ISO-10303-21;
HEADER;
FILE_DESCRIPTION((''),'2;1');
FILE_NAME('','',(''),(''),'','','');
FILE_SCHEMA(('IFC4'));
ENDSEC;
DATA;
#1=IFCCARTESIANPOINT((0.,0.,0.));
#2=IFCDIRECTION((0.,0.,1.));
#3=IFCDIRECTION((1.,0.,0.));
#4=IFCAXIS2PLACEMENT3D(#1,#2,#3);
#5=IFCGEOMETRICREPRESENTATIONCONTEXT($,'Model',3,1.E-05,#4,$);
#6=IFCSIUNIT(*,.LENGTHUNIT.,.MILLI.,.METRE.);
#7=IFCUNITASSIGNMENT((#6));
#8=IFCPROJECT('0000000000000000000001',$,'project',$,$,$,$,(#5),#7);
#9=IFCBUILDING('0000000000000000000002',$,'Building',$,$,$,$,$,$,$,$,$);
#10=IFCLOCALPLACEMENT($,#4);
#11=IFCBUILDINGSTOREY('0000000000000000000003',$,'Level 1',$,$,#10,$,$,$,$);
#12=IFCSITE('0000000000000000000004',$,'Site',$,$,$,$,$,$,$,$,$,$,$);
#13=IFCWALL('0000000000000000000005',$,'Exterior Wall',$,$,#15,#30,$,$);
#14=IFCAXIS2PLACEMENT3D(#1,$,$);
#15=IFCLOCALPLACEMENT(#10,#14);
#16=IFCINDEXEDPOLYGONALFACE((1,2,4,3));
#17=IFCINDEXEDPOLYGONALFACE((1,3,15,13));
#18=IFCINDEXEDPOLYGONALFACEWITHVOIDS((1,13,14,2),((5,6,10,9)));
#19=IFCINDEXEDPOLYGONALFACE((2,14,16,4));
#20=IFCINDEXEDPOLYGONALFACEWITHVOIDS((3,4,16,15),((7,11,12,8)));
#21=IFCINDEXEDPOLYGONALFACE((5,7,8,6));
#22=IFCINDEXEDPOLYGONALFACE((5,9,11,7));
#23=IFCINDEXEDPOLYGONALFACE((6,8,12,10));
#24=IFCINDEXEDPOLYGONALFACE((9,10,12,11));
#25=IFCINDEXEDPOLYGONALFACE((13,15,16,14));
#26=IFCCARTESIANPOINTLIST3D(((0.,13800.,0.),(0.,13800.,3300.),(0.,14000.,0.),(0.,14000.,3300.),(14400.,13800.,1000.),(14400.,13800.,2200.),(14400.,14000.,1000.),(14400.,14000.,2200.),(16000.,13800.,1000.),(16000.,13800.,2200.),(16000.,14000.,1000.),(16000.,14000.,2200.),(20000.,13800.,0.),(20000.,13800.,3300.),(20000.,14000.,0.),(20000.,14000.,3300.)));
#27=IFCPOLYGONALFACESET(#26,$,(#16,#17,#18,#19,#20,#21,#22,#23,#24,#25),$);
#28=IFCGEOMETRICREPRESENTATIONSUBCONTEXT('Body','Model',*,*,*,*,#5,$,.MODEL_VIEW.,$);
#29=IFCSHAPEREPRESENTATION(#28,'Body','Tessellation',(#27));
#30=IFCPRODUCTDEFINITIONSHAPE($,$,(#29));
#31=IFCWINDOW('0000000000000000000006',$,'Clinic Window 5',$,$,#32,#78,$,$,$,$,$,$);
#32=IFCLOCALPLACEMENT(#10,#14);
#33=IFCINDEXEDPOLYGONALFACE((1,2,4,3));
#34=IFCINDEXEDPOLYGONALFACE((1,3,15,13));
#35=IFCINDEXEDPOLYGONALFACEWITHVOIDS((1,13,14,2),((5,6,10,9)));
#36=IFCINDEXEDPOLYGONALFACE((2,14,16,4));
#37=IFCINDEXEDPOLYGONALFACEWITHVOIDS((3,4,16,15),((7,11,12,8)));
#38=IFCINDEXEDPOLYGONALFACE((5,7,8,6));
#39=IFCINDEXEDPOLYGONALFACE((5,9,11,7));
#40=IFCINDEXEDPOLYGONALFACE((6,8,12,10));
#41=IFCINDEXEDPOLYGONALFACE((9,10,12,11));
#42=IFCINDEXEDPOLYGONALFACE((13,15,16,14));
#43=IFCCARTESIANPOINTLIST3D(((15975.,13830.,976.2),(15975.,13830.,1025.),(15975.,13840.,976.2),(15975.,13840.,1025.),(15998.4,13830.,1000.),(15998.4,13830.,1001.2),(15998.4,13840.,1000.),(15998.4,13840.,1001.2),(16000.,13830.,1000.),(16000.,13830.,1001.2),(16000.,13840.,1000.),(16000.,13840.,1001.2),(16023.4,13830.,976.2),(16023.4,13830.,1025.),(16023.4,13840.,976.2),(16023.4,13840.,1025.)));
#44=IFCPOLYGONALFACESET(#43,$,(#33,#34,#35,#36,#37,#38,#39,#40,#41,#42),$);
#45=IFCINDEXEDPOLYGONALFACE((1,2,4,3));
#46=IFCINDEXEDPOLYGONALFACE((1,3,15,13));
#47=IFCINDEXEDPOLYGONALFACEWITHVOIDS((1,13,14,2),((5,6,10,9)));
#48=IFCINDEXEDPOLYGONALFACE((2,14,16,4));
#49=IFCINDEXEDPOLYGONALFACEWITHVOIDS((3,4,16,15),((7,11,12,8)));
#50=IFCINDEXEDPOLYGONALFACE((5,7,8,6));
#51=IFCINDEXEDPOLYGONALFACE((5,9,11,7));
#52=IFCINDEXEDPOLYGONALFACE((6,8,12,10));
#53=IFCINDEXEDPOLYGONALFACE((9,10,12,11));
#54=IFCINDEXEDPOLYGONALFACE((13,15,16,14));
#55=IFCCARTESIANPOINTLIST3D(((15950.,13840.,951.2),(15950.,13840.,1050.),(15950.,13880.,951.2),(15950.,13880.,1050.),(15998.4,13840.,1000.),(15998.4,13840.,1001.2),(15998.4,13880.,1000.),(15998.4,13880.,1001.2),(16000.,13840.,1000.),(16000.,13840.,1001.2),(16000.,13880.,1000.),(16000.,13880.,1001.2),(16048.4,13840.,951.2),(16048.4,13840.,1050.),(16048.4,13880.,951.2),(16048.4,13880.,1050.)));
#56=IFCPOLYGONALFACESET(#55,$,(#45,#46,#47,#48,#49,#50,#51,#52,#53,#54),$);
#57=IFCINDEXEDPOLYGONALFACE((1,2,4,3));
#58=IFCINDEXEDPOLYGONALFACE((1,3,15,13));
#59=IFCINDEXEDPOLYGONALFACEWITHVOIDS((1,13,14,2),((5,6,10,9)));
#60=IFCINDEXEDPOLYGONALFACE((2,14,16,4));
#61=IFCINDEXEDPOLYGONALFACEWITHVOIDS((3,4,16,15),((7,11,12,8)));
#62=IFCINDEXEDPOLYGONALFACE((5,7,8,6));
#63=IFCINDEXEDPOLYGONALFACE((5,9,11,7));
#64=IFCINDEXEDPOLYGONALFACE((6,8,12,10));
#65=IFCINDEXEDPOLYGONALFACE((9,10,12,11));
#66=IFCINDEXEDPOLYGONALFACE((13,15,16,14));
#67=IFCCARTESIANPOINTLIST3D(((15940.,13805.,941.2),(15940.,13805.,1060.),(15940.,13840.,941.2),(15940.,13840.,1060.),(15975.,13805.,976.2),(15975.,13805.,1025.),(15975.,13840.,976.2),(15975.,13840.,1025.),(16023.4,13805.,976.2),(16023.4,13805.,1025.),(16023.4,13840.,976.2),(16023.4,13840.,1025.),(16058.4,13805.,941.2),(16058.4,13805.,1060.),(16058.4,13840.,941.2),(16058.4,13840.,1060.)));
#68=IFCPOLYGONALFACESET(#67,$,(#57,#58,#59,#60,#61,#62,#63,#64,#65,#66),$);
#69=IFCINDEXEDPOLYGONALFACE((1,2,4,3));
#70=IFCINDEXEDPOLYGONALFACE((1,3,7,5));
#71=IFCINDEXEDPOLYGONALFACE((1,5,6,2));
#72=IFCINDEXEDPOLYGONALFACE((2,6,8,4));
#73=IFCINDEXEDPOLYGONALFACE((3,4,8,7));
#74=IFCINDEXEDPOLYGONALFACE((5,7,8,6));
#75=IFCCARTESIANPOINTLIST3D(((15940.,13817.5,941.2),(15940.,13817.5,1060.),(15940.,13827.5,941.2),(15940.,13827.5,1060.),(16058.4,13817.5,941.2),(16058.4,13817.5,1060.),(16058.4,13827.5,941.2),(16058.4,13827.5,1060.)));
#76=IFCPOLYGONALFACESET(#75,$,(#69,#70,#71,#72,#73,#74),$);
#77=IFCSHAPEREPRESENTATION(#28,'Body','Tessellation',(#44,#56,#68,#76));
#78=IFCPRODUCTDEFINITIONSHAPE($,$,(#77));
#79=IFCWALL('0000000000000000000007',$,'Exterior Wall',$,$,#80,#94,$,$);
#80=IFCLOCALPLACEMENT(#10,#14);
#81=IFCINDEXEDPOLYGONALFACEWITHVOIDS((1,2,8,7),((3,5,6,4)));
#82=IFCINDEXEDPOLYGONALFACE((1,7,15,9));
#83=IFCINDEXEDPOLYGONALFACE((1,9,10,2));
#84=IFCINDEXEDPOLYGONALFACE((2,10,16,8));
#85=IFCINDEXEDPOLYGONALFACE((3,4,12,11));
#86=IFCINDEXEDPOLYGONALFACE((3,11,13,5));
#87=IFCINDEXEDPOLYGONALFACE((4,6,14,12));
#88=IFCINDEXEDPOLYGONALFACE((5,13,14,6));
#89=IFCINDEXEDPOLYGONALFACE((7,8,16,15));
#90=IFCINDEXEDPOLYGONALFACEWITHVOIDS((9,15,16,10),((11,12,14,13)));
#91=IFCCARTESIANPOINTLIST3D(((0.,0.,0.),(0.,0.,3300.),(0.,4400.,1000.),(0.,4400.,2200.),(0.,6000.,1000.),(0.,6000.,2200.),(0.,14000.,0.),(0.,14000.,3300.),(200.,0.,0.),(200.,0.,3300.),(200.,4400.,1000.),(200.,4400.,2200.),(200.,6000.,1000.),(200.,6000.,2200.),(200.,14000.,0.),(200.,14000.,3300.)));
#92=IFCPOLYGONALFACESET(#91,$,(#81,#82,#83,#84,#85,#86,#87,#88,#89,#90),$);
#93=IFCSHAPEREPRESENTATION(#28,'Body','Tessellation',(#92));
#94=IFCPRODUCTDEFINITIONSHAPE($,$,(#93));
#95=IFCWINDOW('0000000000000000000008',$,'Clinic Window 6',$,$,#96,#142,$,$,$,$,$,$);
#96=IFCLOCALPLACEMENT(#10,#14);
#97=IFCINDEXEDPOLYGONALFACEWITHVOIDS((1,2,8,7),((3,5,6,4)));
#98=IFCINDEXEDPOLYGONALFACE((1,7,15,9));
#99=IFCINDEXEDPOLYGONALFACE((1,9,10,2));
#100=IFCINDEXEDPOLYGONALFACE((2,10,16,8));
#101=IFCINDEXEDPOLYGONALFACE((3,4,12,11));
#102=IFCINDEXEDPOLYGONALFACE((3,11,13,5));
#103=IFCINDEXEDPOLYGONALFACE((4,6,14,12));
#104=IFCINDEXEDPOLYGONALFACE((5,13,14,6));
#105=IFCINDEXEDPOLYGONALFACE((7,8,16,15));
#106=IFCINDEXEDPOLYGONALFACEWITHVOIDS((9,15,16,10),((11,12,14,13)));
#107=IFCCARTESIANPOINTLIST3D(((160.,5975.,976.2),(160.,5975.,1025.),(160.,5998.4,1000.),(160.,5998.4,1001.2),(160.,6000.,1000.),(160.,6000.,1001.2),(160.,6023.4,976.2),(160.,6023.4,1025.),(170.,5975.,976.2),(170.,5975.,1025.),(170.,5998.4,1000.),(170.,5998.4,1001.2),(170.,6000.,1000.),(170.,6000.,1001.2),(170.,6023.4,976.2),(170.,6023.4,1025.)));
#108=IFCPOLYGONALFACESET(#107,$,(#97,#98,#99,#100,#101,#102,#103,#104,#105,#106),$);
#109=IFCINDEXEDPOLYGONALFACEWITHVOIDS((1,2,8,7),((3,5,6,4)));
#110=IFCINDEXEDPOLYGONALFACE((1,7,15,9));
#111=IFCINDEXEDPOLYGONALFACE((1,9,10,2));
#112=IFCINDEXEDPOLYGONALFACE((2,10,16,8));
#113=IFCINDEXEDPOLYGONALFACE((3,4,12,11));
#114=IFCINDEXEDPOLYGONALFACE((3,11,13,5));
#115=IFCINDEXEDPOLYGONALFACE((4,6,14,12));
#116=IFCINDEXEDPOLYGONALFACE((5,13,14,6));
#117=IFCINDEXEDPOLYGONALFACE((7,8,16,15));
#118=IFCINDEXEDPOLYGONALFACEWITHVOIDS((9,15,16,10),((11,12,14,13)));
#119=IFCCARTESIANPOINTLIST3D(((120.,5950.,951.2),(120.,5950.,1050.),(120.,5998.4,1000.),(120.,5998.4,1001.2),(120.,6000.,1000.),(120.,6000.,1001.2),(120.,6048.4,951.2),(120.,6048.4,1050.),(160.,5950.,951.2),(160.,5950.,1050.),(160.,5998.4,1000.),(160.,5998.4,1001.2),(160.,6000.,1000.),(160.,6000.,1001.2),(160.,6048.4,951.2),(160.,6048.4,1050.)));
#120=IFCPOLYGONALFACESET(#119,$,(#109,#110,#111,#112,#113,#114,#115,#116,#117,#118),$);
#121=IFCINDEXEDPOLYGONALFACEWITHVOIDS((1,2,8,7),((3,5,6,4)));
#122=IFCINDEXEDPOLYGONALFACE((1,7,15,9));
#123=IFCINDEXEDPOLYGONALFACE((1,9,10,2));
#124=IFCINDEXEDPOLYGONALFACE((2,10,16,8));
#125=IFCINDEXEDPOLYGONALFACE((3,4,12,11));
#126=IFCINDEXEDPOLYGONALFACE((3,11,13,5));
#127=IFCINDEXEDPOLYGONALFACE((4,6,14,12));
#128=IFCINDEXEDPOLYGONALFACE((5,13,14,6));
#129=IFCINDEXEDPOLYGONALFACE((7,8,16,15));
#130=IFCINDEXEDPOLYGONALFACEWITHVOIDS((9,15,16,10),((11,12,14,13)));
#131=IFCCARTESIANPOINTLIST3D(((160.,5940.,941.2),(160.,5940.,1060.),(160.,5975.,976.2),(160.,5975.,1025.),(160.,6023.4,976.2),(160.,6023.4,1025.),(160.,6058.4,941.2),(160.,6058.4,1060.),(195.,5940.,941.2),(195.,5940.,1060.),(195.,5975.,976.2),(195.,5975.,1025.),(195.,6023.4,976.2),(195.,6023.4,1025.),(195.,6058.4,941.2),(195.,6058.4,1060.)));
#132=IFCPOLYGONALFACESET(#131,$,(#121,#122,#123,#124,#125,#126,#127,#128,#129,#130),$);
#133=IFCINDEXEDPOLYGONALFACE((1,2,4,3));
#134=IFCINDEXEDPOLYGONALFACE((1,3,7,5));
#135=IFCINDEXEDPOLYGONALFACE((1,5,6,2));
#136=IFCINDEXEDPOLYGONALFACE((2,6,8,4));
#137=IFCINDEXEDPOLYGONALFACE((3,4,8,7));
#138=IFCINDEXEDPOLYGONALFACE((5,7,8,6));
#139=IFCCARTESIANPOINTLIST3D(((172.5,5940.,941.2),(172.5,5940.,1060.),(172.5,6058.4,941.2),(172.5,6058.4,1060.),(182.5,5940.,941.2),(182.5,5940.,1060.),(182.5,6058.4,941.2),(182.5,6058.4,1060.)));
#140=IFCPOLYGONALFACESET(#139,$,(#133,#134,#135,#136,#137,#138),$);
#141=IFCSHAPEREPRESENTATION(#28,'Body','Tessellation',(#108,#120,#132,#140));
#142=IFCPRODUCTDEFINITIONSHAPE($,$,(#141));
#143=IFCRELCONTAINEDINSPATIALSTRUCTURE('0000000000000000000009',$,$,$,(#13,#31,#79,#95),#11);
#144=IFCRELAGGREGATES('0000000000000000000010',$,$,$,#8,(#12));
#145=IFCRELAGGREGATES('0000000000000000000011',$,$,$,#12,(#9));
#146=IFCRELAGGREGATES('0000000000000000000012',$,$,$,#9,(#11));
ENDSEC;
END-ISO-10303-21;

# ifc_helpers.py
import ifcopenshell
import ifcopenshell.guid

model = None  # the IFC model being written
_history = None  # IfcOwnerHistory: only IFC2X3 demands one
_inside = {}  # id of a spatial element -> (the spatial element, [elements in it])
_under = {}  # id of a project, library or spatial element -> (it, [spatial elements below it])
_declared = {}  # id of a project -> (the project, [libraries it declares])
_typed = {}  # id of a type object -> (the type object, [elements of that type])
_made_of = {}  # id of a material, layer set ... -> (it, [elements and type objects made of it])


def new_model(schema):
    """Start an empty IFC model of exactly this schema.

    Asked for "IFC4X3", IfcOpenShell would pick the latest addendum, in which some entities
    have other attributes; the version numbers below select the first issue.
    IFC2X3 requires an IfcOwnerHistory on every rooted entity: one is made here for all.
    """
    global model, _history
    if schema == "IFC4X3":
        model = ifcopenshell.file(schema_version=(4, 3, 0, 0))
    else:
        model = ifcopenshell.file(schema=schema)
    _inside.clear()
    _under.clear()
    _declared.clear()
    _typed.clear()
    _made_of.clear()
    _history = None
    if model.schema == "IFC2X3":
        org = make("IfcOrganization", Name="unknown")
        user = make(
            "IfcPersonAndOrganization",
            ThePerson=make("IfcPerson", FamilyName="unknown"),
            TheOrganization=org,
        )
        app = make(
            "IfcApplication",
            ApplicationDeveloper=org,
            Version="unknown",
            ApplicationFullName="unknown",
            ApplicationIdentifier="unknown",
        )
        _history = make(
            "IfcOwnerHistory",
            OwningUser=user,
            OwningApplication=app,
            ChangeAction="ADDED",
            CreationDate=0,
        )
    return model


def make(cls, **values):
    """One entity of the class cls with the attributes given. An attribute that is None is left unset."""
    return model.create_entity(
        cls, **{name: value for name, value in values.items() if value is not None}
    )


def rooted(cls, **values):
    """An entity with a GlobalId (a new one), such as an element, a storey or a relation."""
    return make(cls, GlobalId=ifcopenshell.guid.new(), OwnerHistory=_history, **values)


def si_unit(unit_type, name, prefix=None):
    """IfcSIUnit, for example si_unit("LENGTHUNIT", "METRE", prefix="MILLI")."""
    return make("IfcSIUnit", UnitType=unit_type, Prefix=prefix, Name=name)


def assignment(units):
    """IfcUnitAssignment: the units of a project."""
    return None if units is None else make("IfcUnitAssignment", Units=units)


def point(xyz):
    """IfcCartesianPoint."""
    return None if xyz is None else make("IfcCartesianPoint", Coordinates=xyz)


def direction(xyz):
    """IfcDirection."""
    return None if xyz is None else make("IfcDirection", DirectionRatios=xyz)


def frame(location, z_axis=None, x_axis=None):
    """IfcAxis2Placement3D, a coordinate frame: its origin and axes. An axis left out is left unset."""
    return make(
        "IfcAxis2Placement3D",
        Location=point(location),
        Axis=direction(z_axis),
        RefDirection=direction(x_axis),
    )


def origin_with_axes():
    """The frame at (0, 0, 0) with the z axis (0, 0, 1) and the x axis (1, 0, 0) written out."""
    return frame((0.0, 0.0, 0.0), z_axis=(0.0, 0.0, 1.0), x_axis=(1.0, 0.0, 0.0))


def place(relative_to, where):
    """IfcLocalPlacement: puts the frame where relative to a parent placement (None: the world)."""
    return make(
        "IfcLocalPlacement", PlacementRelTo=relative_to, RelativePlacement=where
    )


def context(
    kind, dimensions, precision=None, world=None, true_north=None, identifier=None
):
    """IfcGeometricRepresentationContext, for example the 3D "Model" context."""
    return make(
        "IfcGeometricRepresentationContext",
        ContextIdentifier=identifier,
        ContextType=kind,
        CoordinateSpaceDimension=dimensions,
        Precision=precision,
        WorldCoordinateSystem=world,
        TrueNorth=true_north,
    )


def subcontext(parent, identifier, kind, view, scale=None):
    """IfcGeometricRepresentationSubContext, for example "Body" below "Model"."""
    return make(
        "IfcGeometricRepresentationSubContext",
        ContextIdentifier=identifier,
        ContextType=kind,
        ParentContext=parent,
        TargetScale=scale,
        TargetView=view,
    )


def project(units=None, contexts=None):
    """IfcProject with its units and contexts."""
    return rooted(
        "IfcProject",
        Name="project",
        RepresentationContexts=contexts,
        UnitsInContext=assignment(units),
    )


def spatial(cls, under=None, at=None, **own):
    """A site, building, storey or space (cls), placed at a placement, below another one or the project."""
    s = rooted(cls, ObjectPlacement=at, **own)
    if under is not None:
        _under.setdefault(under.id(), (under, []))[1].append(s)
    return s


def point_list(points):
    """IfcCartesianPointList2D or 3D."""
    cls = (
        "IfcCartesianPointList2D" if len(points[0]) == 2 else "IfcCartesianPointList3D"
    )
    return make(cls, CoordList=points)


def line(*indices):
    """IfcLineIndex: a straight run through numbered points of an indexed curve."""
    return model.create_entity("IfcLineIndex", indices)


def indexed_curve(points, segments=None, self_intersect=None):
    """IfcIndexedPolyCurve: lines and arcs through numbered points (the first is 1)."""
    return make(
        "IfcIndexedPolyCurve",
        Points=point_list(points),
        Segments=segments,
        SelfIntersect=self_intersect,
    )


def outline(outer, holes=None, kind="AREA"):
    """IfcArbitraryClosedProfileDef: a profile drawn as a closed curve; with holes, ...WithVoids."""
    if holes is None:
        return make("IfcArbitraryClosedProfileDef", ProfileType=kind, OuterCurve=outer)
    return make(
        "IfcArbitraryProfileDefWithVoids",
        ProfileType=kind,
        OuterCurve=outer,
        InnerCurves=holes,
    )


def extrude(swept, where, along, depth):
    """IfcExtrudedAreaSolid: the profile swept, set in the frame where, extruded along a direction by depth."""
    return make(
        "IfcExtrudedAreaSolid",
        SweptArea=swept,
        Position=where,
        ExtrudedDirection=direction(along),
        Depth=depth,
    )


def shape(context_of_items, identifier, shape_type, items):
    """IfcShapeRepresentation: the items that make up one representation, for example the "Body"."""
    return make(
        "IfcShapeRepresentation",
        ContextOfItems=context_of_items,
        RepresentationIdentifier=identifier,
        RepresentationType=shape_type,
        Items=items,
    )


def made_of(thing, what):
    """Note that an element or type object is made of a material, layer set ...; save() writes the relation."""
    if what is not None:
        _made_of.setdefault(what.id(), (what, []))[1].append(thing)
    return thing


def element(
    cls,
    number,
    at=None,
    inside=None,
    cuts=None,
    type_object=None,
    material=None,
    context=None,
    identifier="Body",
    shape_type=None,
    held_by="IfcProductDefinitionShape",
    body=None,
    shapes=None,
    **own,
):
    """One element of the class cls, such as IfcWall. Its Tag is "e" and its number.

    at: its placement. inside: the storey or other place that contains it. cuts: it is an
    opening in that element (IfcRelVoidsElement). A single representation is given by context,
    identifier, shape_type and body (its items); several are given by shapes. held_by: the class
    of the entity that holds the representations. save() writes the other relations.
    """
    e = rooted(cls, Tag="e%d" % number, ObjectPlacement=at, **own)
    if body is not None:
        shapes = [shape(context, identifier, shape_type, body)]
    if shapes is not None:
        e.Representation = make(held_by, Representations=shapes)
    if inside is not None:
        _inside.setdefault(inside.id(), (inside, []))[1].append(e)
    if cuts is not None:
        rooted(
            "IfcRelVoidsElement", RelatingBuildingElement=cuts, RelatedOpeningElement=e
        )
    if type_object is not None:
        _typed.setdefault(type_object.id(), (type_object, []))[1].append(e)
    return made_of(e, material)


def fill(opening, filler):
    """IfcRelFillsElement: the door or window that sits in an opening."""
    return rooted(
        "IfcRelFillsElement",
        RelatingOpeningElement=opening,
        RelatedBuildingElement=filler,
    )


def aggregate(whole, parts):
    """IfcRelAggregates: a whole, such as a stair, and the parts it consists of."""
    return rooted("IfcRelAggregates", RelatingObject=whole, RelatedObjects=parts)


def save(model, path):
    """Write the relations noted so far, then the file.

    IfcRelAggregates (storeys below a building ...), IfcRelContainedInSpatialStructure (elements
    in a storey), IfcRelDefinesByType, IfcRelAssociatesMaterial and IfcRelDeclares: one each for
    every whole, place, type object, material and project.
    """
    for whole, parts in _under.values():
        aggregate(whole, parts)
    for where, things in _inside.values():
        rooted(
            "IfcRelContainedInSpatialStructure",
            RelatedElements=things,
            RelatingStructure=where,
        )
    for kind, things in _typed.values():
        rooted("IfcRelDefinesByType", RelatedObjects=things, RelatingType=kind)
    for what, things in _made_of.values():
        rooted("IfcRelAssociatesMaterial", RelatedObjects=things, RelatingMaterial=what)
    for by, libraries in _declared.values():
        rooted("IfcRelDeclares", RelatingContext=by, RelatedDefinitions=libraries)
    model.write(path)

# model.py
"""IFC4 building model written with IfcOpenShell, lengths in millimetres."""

from ifc_helpers import new_model, si_unit, frame, origin_with_axes, place, context, subcontext, project, spatial, line, indexed_curve, outline, extrude, element, fill, save


model = new_model("IFC4")

# Units and contexts
model_context = context("Model", 3, precision=1e-05, world=origin_with_axes())
body_context = subcontext(model_context, "Body", "Model", "MODEL_VIEW")
ifc_project = project(units=[si_unit("LENGTHUNIT", "METRE", prefix="MILLI")], contexts=[model_context])

# Site, building, storey
site = spatial("IfcSite", under=ifc_project, Name="Site")
building = spatial("IfcBuilding", under=site, Name="Building")
storey_placement = place(None, origin_with_axes())
storey = spatial("IfcBuildingStorey", under=building, at=storey_placement, Name="Level 1")

# Walls, openings, windows
wall_1_placement = place(storey_placement, frame((20000.0, 14000.0, 0.0), z_axis=(0.0, 0.0, 1.0), x_axis=(-1.0, 0.0, 0.0)))
wall_1 = element("IfcWall", 1, at=wall_1_placement, inside=storey, Name="Exterior Wall", context=body_context, shape_type="SweptSolid", body=[
    extrude(outline(indexed_curve([(0.0, 0.0), (0.0, 200.0), (20000.0, 200.0), (20000.0, 0.0), (0.0, 0.0)], self_intersect=False)), origin_with_axes(), (0.0, 0.0, 1.0), 3300.0),
])
opening_1_placement = place(wall_1_placement, frame((4000.0, -100.0, 1000.0), z_axis=(0.0, 0.0, 1.0), x_axis=(1.0, 0.0, 0.0)))
opening_1 = element("IfcOpeningElement", 2, at=opening_1_placement, cuts=wall_1, context=body_context, shape_type="SweptSolid", body=[
    extrude(outline(indexed_curve([(0.0, 0.0), (0.0, 400.0), (1600.0, 400.0), (1600.0, 0.0), (0.0, 0.0)], self_intersect=False)), origin_with_axes(), (0.0, 0.0, 1.0), 1200.0),
])
window_1_placement = place(opening_1_placement, frame((0.0, 170.0, 0.0), z_axis=(0.0, 0.0, 1.0), x_axis=(1.0, 0.0, 0.0)))
window_1 = element("IfcWindow", 3, at=window_1_placement, inside=storey, Name="Clinic Window 5", context=body_context, shape_type="SweptSolid", body=[
    extrude(outline(indexed_curve([(0.0, 0.0), (1.6, 0.0), (1.6, 1.2), (0.0, 1.2)], segments=[line(1, 2, 3, 4, 1)]), holes=[indexed_curve([(25.0, 25.0), (-23.4, 25.0), (-23.4, -23.8), (25.0, -23.8)], segments=[line(1, 2, 3, 4, 1)])]), frame((0.0, 90.0, 0.0), z_axis=(0.0, -1.0, 0.0), x_axis=(1.0, 0.0, 0.0)), (0.0, 0.0, -1.0), 10.0),
    extrude(outline(indexed_curve([(0.0, 0.0), (1.6, 0.0), (1.6, 1.2), (0.0, 1.2)], segments=[line(1, 2, 3, 4, 1)]), holes=[indexed_curve([(50.0, 50.0), (-48.4, 50.0), (-48.4, -48.8), (50.0, -48.8)], segments=[line(1, 2, 3, 4, 1)])]), frame((0.0, 50.0, 0.0), z_axis=(0.0, -1.0, 0.0), x_axis=(1.0, 0.0, 0.0)), (0.0, 0.0, -1.0), 40.0),
    extrude(outline(indexed_curve([(0.0, 0.0), (-48.4, 0.0), (-48.4, -48.8), (0.0, -48.8)], segments=[line(1, 2, 3, 4, 1)]), holes=[indexed_curve([(35.0, 35.0), (-83.4, 35.0), (-83.4, -83.8), (35.0, -83.8)], segments=[line(1, 2, 3, 4, 1)])]), frame((25.0, 90.0, 25.0), z_axis=(0.0, -1.0, 0.0), x_axis=(1.0, 0.0, 0.0)), (0.0, 0.0, -1.0), 35.0),
    extrude(outline(indexed_curve([(35.0, 35.0), (-83.4, 35.0), (-83.4, -83.8), (35.0, -83.8)], segments=[line(1, 2, 3, 4, 1)])), frame((25.0, 102.5, 25.0), z_axis=(0.0, -1.0, 0.0), x_axis=(1.0, 0.0, 0.0)), (0.0, 0.0, -1.0), 10.0),
])
fill(opening_1, window_1)
wall_2_placement = place(storey_placement, frame((0.0, 14000.0, 0.0), z_axis=(0.0, 0.0, 1.0), x_axis=(0.0, -1.0, 0.0)))
wall_2 = element("IfcWall", 4, at=wall_2_placement, inside=storey, Name="Exterior Wall", context=body_context, shape_type="SweptSolid", body=[
    extrude(outline(indexed_curve([(0.0, 0.0), (0.0, 200.0), (14000.0, 200.0), (14000.0, 0.0), (0.0, 0.0)], self_intersect=False)), origin_with_axes(), (0.0, 0.0, 1.0), 3300.0),
])
opening_2_placement = place(wall_2_placement, frame((8000.0, -100.0, 1000.0), z_axis=(0.0, 0.0, 1.0), x_axis=(1.0, 0.0, 0.0)))
opening_2 = element("IfcOpeningElement", 5, at=opening_2_placement, cuts=wall_2, context=body_context, shape_type="SweptSolid", body=[
    extrude(outline(indexed_curve([(0.0, 0.0), (0.0, 400.0), (1600.0, 400.0), (1600.0, 0.0), (0.0, 0.0)], self_intersect=False)), origin_with_axes(), (0.0, 0.0, 1.0), 1200.0),
])
window_2_placement = place(opening_2_placement, frame((0.0, 170.0, 0.0), z_axis=(0.0, 0.0, 1.0), x_axis=(1.0, 0.0, 0.0)))
window_2 = element("IfcWindow", 6, at=window_2_placement, inside=storey, Name="Clinic Window 6", context=body_context, shape_type="SweptSolid", body=[
    extrude(outline(indexed_curve([(0.0, 0.0), (1.6, 0.0), (1.6, 1.2), (0.0, 1.2)], segments=[line(1, 2, 3, 4, 1)]), holes=[indexed_curve([(25.0, 25.0), (-23.4, 25.0), (-23.4, -23.8), (25.0, -23.8)], segments=[line(1, 2, 3, 4, 1)])]), frame((0.0, 90.0, 0.0), z_axis=(0.0, -1.0, 0.0), x_axis=(1.0, 0.0, 0.0)), (0.0, 0.0, -1.0), 10.0),
    extrude(outline(indexed_curve([(0.0, 0.0), (1.6, 0.0), (1.6, 1.2), (0.0, 1.2)], segments=[line(1, 2, 3, 4, 1)]), holes=[indexed_curve([(50.0, 50.0), (-48.4, 50.0), (-48.4, -48.8), (50.0, -48.8)], segments=[line(1, 2, 3, 4, 1)])]), frame((0.0, 50.0, 0.0), z_axis=(0.0, -1.0, 0.0), x_axis=(1.0, 0.0, 0.0)), (0.0, 0.0, -1.0), 40.0),
    extrude(outline(indexed_curve([(0.0, 0.0), (-48.4, 0.0), (-48.4, -48.8), (0.0, -48.8)], segments=[line(1, 2, 3, 4, 1)]), holes=[indexed_curve([(35.0, 35.0), (-83.4, 35.0), (-83.4, -83.8), (35.0, -83.8)], segments=[line(1, 2, 3, 4, 1)])]), frame((25.0, 90.0, 25.0), z_axis=(0.0, -1.0, 0.0), x_axis=(1.0, 0.0, 0.0)), (0.0, 0.0, -1.0), 35.0),
    extrude(outline(indexed_curve([(35.0, 35.0), (-83.4, 35.0), (-83.4, -83.8), (35.0, -83.8)], segments=[line(1, 2, 3, 4, 1)])), frame((25.0, 102.5, 25.0), z_axis=(0.0, -1.0, 0.0), x_axis=(1.0, 0.0, 0.0)), (0.0, 0.0, -1.0), 10.0),
])
fill(opening_2, window_2)

save(model, "model.ifc")
